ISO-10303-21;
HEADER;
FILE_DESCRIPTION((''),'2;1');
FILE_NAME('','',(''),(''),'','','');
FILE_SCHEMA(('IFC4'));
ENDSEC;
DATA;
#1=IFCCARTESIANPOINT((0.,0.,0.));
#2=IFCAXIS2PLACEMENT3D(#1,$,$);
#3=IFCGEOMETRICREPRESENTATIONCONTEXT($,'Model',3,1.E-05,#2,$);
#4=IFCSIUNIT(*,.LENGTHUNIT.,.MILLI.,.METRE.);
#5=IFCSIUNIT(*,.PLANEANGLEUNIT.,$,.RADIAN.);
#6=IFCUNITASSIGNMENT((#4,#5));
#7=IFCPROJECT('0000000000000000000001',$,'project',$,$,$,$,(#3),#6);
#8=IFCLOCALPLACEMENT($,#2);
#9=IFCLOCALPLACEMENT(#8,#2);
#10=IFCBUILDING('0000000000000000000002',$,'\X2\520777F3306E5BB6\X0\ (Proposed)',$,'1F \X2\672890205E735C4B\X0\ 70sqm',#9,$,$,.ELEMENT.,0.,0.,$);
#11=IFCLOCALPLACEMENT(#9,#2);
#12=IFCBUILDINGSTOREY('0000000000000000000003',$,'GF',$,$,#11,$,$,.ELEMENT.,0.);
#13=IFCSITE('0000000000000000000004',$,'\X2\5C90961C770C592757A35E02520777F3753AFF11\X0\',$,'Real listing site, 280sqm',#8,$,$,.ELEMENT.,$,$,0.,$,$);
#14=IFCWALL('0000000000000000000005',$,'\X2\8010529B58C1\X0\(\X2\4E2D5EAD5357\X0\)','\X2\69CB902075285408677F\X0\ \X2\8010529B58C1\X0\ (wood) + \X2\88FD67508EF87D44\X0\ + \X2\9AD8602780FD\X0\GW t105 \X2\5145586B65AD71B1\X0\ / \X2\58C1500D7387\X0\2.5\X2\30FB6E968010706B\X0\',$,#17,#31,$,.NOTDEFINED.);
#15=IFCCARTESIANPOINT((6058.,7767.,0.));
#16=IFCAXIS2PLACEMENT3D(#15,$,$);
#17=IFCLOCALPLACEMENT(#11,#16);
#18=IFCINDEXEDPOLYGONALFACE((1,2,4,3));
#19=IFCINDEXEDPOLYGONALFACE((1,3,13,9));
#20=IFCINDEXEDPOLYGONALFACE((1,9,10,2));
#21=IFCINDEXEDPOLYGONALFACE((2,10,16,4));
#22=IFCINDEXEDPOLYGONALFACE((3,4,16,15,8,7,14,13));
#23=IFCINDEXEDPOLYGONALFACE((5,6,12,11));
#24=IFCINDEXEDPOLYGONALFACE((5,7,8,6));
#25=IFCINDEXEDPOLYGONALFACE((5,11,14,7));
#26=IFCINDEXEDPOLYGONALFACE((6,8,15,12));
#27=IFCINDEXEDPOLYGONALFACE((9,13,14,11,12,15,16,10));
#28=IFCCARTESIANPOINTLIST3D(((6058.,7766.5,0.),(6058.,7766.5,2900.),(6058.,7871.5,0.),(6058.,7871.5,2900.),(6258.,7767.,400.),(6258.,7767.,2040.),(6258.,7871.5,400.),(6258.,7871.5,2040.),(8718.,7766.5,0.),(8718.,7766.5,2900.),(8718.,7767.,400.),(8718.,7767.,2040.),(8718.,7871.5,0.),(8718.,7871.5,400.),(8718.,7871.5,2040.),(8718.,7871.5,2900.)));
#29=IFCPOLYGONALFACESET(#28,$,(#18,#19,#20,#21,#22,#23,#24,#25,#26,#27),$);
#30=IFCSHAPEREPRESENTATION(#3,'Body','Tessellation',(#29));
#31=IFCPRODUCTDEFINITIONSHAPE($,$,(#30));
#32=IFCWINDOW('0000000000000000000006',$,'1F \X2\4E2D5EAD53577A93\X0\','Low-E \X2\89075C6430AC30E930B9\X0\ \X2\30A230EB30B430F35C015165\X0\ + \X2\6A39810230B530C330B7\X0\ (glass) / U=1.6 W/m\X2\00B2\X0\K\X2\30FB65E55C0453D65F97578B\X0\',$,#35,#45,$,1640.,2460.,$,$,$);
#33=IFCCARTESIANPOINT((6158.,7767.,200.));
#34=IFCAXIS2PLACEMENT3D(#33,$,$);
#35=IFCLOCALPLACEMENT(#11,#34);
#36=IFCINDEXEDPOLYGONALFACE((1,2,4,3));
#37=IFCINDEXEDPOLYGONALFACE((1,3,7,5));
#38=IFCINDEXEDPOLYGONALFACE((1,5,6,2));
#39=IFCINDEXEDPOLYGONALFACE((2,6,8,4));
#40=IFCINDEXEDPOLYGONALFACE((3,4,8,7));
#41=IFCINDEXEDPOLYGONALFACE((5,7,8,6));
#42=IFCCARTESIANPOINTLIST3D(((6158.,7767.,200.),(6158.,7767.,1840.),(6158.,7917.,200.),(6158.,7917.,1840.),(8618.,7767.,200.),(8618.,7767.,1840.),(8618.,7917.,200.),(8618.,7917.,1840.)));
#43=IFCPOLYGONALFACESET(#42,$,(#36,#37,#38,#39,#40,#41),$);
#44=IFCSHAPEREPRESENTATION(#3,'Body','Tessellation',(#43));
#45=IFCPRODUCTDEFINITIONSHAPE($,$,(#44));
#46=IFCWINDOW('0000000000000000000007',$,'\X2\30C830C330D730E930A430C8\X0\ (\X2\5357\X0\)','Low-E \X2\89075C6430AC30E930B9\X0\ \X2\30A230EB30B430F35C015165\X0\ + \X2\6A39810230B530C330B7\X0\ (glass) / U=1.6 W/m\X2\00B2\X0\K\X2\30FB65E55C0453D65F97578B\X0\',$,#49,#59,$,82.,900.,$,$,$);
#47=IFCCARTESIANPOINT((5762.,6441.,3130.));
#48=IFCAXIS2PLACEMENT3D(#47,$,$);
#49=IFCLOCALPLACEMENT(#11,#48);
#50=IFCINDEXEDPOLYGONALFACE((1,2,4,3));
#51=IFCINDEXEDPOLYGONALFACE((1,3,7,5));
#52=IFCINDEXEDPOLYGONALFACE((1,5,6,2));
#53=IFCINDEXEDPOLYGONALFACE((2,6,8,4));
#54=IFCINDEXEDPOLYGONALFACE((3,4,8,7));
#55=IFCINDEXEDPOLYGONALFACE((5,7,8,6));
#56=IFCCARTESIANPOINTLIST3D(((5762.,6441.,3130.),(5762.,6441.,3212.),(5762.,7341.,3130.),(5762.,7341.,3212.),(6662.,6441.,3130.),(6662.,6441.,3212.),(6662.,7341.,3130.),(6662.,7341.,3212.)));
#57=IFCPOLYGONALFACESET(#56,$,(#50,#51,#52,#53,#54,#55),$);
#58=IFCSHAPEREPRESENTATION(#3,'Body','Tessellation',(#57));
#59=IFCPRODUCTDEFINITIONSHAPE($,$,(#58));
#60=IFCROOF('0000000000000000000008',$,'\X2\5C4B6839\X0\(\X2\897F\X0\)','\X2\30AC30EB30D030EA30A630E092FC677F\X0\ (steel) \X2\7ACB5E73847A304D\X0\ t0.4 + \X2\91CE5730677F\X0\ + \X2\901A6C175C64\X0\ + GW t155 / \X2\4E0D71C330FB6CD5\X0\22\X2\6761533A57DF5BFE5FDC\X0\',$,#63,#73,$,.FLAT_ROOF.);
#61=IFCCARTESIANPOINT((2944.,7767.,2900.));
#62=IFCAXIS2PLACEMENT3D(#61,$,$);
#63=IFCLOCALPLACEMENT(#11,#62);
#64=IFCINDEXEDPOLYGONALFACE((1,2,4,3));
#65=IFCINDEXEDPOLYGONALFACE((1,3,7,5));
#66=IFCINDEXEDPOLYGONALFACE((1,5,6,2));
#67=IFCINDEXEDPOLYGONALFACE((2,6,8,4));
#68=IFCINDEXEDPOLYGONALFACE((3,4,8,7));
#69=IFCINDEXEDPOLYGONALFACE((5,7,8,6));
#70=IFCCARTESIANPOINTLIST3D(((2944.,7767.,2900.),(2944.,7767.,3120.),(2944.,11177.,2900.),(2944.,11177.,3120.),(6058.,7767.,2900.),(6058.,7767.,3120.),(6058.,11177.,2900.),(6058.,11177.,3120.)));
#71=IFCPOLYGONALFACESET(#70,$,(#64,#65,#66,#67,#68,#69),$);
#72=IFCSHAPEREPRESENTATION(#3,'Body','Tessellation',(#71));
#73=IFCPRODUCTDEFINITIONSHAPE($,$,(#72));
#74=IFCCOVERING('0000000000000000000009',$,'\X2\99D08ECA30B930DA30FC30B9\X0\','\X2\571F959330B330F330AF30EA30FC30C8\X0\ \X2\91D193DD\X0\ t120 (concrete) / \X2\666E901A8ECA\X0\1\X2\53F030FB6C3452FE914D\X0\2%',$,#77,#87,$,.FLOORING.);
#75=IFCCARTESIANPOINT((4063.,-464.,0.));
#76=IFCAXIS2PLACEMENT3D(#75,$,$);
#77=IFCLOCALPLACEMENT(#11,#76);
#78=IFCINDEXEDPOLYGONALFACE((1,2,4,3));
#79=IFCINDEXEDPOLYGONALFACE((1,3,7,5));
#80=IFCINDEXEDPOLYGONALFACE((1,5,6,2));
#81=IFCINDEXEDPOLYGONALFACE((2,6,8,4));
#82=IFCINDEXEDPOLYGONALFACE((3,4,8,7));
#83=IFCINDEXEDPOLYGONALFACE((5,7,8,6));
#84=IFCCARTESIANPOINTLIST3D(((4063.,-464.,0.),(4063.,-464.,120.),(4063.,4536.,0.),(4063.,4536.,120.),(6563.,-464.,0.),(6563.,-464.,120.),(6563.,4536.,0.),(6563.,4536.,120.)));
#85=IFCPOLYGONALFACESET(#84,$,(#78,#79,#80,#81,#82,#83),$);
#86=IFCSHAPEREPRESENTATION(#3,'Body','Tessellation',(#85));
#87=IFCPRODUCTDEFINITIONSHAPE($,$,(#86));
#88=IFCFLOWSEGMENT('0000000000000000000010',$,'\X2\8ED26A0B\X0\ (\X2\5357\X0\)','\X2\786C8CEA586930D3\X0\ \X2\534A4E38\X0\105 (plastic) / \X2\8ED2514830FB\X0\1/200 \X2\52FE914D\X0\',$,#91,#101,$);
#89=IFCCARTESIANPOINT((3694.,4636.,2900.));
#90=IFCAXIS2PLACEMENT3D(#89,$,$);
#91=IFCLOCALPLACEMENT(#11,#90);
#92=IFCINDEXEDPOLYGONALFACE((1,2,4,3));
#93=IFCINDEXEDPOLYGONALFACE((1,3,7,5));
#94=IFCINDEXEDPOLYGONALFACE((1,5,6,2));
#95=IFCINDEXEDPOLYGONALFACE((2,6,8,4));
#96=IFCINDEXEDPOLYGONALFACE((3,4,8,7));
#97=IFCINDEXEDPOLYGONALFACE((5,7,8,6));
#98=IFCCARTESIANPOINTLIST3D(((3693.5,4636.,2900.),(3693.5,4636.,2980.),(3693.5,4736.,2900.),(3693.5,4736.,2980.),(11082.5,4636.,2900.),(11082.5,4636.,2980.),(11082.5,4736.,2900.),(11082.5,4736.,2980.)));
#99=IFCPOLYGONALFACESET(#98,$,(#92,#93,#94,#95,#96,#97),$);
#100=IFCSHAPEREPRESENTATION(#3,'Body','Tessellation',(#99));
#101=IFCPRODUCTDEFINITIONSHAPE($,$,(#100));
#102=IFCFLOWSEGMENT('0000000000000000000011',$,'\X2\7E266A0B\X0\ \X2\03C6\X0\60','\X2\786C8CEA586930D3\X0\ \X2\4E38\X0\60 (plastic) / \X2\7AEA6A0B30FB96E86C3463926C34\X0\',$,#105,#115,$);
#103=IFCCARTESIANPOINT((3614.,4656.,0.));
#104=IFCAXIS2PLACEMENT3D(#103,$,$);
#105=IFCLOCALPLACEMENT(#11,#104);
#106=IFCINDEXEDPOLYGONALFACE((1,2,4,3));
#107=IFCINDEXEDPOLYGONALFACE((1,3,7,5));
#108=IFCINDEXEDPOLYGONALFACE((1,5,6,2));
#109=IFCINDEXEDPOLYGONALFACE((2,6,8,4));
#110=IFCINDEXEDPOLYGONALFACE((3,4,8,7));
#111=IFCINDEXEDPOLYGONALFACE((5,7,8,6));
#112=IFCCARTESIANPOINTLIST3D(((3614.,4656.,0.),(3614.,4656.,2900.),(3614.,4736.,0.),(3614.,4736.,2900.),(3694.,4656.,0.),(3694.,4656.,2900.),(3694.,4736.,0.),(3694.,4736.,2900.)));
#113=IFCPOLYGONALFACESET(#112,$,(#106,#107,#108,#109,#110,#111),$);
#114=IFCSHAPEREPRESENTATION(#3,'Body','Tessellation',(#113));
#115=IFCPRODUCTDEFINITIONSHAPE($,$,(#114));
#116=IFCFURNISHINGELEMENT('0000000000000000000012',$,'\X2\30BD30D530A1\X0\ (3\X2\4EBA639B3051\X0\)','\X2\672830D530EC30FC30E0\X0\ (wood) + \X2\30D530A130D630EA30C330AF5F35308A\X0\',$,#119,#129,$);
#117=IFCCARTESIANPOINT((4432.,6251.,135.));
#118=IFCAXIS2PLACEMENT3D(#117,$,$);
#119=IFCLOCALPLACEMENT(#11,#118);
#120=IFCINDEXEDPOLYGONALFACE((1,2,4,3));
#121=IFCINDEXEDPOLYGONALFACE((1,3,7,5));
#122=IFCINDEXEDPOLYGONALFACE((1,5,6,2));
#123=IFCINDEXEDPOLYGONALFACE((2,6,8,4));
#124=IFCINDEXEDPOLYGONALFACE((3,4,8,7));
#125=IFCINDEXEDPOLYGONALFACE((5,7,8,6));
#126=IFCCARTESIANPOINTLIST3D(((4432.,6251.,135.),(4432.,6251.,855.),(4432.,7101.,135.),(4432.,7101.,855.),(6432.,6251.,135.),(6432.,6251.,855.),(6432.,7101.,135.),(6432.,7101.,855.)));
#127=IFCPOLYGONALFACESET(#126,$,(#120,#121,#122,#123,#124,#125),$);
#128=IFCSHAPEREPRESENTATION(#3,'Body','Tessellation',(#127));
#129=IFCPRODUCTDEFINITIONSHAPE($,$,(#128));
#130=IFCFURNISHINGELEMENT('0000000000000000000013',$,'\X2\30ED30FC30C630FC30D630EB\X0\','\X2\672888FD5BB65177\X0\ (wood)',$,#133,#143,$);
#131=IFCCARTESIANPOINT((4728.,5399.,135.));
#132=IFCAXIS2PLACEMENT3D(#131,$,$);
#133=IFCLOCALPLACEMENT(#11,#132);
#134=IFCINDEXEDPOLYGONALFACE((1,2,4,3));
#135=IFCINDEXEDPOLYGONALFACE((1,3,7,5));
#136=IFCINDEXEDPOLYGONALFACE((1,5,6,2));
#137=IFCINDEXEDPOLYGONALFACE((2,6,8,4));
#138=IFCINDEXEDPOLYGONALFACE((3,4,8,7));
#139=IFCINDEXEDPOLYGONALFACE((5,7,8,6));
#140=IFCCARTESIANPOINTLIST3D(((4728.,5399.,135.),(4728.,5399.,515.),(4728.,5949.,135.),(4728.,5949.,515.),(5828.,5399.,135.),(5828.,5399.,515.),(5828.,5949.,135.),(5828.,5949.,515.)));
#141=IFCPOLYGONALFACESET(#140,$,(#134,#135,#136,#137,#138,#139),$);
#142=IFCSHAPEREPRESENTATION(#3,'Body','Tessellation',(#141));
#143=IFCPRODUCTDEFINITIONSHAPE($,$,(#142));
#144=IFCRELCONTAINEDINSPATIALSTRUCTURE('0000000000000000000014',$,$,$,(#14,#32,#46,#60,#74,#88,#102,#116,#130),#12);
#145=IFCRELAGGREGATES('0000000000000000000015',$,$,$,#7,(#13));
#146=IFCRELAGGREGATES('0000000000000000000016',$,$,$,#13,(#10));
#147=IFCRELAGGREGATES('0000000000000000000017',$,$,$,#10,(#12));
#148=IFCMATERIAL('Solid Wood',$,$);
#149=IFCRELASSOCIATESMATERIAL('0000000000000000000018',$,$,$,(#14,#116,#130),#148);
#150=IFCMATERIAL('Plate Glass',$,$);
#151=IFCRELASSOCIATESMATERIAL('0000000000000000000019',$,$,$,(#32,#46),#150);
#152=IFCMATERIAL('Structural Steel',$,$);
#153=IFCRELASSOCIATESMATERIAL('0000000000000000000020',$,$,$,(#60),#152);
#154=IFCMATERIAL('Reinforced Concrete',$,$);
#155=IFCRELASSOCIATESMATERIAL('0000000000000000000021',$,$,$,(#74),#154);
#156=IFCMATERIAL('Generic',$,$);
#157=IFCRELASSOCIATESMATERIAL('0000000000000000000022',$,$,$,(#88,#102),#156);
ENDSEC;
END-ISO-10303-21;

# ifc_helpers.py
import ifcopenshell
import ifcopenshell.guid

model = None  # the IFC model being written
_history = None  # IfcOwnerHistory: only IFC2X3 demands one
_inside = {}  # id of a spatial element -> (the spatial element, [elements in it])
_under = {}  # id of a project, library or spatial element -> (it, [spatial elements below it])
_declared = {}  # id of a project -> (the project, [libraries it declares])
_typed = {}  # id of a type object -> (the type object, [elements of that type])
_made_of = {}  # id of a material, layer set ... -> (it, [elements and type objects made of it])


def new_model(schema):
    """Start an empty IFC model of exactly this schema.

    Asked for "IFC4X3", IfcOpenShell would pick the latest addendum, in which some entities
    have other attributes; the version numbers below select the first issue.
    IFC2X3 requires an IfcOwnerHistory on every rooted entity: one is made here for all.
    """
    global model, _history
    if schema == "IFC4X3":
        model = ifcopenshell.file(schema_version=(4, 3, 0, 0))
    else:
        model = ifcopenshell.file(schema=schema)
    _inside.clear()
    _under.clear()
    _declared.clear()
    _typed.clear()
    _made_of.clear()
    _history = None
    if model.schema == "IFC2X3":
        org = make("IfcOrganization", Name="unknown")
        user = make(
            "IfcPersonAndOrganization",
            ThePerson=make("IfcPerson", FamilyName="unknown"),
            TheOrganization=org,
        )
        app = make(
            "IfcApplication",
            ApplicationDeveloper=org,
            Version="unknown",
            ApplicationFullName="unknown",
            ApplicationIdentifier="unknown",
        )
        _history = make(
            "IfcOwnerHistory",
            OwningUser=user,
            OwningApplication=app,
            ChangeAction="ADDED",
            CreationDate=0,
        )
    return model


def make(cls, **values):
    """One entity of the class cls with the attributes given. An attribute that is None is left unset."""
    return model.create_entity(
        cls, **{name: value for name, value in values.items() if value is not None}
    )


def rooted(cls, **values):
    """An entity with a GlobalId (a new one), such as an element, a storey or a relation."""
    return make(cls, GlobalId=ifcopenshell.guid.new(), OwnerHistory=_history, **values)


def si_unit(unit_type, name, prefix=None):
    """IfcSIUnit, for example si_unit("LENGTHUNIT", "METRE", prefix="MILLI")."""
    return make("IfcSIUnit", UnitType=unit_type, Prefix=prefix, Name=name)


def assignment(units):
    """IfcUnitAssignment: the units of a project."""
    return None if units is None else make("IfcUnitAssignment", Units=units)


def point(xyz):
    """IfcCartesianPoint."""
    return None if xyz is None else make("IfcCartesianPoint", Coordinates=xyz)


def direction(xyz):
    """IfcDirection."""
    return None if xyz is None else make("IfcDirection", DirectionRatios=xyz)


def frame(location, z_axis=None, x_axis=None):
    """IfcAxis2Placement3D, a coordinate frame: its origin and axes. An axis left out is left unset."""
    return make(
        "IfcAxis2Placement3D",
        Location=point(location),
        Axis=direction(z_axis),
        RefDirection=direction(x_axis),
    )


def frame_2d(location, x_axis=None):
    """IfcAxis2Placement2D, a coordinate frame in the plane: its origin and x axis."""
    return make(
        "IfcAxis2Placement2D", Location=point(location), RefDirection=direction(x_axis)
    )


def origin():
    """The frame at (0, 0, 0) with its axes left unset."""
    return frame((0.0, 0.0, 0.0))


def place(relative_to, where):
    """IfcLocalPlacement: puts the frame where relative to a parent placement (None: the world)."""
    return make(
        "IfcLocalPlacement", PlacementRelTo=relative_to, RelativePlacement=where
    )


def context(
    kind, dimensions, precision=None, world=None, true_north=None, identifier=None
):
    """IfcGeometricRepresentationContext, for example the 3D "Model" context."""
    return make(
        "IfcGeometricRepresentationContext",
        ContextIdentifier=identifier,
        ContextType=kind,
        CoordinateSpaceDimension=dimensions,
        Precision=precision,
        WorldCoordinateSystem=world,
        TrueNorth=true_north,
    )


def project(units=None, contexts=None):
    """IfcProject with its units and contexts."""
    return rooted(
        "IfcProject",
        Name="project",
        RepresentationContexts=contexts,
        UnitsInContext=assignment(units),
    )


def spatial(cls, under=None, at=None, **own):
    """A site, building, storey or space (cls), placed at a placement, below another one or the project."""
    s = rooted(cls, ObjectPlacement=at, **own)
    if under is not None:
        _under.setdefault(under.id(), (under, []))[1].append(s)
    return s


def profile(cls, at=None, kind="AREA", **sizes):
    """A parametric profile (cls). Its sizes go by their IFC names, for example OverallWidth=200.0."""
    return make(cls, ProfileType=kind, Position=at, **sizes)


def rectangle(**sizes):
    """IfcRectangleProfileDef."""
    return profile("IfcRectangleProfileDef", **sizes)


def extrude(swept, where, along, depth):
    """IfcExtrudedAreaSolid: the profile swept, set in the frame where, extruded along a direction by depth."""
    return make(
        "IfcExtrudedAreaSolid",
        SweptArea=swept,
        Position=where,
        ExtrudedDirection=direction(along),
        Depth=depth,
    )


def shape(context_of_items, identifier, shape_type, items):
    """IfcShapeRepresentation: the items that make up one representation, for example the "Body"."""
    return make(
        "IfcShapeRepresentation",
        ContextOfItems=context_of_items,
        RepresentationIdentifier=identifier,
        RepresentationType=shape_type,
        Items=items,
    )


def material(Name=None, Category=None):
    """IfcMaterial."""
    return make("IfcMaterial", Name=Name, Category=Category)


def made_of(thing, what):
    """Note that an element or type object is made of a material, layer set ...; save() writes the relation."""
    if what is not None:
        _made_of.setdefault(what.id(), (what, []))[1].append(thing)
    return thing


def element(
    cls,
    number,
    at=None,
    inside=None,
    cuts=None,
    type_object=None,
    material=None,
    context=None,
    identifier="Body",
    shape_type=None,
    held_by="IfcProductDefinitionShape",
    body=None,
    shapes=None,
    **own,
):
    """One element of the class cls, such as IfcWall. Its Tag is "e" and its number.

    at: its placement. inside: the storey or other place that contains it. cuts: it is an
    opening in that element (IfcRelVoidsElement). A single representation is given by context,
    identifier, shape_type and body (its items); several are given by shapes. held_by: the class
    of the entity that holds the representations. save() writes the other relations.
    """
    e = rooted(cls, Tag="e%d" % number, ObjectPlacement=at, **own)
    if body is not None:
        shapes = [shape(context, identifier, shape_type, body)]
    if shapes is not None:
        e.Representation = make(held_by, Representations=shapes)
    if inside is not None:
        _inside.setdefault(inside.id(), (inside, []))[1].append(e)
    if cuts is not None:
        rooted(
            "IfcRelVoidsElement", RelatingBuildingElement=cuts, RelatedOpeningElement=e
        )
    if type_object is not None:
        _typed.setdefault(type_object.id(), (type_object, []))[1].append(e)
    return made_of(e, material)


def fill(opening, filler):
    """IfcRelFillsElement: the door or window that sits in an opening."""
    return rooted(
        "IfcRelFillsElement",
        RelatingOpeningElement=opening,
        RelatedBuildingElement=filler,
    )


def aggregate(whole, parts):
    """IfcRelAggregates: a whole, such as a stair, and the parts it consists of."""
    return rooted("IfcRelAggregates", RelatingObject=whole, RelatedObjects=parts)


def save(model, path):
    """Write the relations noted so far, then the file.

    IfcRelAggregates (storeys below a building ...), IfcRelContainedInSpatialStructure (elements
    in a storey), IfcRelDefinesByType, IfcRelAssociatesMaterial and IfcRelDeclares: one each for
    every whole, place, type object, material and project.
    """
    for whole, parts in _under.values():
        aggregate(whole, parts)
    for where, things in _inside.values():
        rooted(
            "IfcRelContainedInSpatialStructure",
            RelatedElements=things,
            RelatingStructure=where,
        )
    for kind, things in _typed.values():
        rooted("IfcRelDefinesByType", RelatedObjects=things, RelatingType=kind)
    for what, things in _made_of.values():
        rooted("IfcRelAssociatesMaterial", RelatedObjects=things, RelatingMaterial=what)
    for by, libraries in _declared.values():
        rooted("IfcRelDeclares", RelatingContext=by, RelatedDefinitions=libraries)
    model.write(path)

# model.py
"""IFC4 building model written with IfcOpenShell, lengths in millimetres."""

from ifc_helpers import new_model, si_unit, frame, frame_2d, origin, place, context, project, spatial, rectangle, extrude, material, element, fill, save


model = new_model("IFC4")

# Units and contexts
model_context = context("Model", 3, precision=1e-05, world=origin())
ifc_project = project(units=[si_unit("LENGTHUNIT", "METRE", prefix="MILLI"), si_unit("PLANEANGLEUNIT", "RADIAN")], contexts=[model_context])

# Site, building, storey
site_placement = place(None, origin())
site = spatial("IfcSite", under=ifc_project, at=site_placement, Name="岐阜県大垣市切石町１", ObjectType="Real listing site, 280sqm", CompositionType="ELEMENT", RefElevation=0.0)
building_placement = place(site_placement, origin())
building = spatial("IfcBuilding", under=site, at=building_placement, Name="切石の家 (Proposed)", ObjectType="1F 木造平屋 70sqm", CompositionType="ELEMENT", ElevationOfRefHeight=0.0, ElevationOfTerrain=0.0)
storey_placement = place(building_placement, origin())
storey = spatial("IfcBuildingStorey", under=building, at=storey_placement, Name="GF", CompositionType="ELEMENT", Elevation=0.0)

# Shared definitions
ifc_material_1 = material(Name="Solid Wood")

# Shared definitions
ifc_material_2 = material(Name="Reinforced Concrete")

# Shared definitions
ifc_material_3 = material(Name="Plate Glass")

# Wall, opening, window
wall_1_placement = place(storey_placement, frame((6058.0, 7767.0, 0.0)))
wall_1 = element("IfcWall", 1, at=wall_1_placement, inside=storey, material=ifc_material_1, Name="耐力壁(中庭南)", Description="構造用合板 耐力壁 (wood) + 製材軸組 + 高性能GW t105 充填断熱 / 壁倍率2.5・準耐火", PredefinedType="NOTDEFINED", context=model_context, shape_type="SweptSolid", body=[
    extrude(rectangle(XDim=2660.0, YDim=105.0, at=frame_2d((1330.0, 52.0))), frame((6058.0, 7767.0, 0.0)), (0.0, 0.0, 1.0), 2900.0),
])
opening_1_placement = place(storey_placement, frame((6158.0, 7767.0, 200.0)))
opening_1 = element("IfcOpeningElement", 2, at=opening_1_placement, cuts=wall_1, PredefinedType="NOTDEFINED", context=model_context, shape_type="SweptSolid", body=[
    extrude(rectangle(XDim=2460.0, YDim=150.0, at=frame_2d((1230.0, 75.0))), frame((6158.0, 7767.0, 200.0)), (0.0, 0.0, 1.0), 1640.0),
])
window_1_placement = place(storey_placement, frame((6158.0, 7767.0, 200.0)))
window_1 = element("IfcWindow", 3, at=window_1_placement, inside=storey, material=ifc_material_3, Name="1F 中庭南窓", Description="Low-E 複層ガラス アルゴン封入 + 樹脂サッシ (glass) / U=1.6 W/m²K・日射取得型", OverallHeight=1640.0, OverallWidth=2460.0, context=model_context, shape_type="SweptSolid", body=[
    extrude(rectangle(XDim=2460.0, YDim=150.0, at=frame_2d((1230.0, 75.0))), frame((6158.0, 7767.0, 200.0)), (0.0, 0.0, 1.0), 1640.0),
])
fill(opening_1, window_1)

# Window
window_2_placement = place(storey_placement, frame((5762.0, 6441.0, 3130.0)))
element("IfcWindow", 4, at=window_2_placement, inside=storey, material=ifc_material_3, Name="トップライト (南)", Description="Low-E 複層ガラス アルゴン封入 + 樹脂サッシ (glass) / U=1.6 W/m²K・日射取得型", OverallHeight=82.0, OverallWidth=900.0, context=model_context, shape_type="SweptSolid", body=[
    extrude(rectangle(XDim=900.0, YDim=900.0, at=frame_2d((450.0, 450.0))), frame((5762.0, 6441.0, 3130.0)), (0.0, 0.0, 1.0), 82.0),
])

# Roof
ifc_material_4 = material(Name="Structural Steel")
roof_1_placement = place(storey_placement, frame((2944.0, 7767.0, 2900.0)))
element("IfcRoof", 5, at=roof_1_placement, inside=storey, material=ifc_material_4, Name="屋根(西)", Description="ガルバリウム鋼板 (steel) 立平葺き t0.4 + 野地板 + 通気層 + GW t155 / 不燃・法22条区域対応", PredefinedType="FLAT_ROOF", context=model_context, shape_type="SweptSolid", body=[
    extrude(rectangle(XDim=3114.0, YDim=3410.0, at=frame_2d((1557.0, 1705.0))), frame((2944.0, 7767.0, 2900.0)), (0.0, 0.0, 1.0), 220.0),
])

# Covering
ifc_material_5 = material(Name="Generic")
covering_1_placement = place(storey_placement, frame((4063.0, -464.0, 0.0)))
element("IfcCovering", 6, at=covering_1_placement, inside=storey, material=ifc_material_2, Name="駐車スペース", Description="土間コンクリート 金鏝 t120 (concrete) / 普通車1台・水勾配2%", PredefinedType="FLOORING", context=model_context, shape_type="SweptSolid", body=[
    extrude(rectangle(XDim=2500.0, YDim=5000.0, at=frame_2d((1250.0, 2500.0))), frame((4063.0, -464.0, 0.0)), (0.0, 0.0, 1.0), 120.0),
])

# Flow segments
flow_segment_1_placement = place(storey_placement, frame((3694.0, 4636.0, 2900.0)))
element("IfcFlowSegment", 7, at=flow_segment_1_placement, inside=storey, material=ifc_material_5, Name="軒樋 (南)", Description="硬質塩ビ 半丸105 (plastic) / 軒先・1/200 勾配", context=model_context, shape_type="SweptSolid", body=[
    extrude(rectangle(XDim=7389.0, YDim=100.0, at=frame_2d((3694.0, 50.0))), frame((3694.0, 4636.0, 2900.0)), (0.0, 0.0, 1.0), 80.0),
])
flow_segment_2_placement = place(storey_placement, frame((3614.0, 4656.0, 0.0)))
element("IfcFlowSegment", 8, at=flow_segment_2_placement, inside=storey, material=ifc_material_5, Name="縦樋 φ60", Description="硬質塩ビ 丸60 (plastic) / 竪樋・雨水排水", context=model_context, shape_type="SweptSolid", body=[
    extrude(rectangle(XDim=80.0, YDim=80.0, at=frame_2d((40.0, 40.0))), frame((3614.0, 4656.0, 0.0)), (0.0, 0.0, 1.0), 2900.0),
])

# Furnishing elements
furnishing_1_placement = place(storey_placement, frame((4432.0, 6251.0, 135.0)))
element("IfcFurnishingElement", 9, at=furnishing_1_placement, inside=storey, material=ifc_material_1, Name="ソファ (3人掛け)", Description="木フレーム (wood) + ファブリック張り", context=model_context, shape_type="SweptSolid", body=[
    extrude(rectangle(XDim=2000.0, YDim=850.0, at=frame_2d((1000.0, 425.0))), frame((4432.0, 6251.0, 135.0)), (0.0, 0.0, 1.0), 720.0),
])
furnishing_2_placement = place(storey_placement, frame((4728.0, 5399.0, 135.0)))
element("IfcFurnishingElement", 10, at=furnishing_2_placement, inside=storey, material=ifc_material_1, Name="ローテーブル", Description="木製家具 (wood)", context=model_context, shape_type="SweptSolid", body=[
    extrude(rectangle(XDim=1100.0, YDim=550.0, at=frame_2d((550.0, 275.0))), frame((4728.0, 5399.0, 135.0)), (0.0, 0.0, 1.0), 380.0),
])

save(model, "model.ifc")
